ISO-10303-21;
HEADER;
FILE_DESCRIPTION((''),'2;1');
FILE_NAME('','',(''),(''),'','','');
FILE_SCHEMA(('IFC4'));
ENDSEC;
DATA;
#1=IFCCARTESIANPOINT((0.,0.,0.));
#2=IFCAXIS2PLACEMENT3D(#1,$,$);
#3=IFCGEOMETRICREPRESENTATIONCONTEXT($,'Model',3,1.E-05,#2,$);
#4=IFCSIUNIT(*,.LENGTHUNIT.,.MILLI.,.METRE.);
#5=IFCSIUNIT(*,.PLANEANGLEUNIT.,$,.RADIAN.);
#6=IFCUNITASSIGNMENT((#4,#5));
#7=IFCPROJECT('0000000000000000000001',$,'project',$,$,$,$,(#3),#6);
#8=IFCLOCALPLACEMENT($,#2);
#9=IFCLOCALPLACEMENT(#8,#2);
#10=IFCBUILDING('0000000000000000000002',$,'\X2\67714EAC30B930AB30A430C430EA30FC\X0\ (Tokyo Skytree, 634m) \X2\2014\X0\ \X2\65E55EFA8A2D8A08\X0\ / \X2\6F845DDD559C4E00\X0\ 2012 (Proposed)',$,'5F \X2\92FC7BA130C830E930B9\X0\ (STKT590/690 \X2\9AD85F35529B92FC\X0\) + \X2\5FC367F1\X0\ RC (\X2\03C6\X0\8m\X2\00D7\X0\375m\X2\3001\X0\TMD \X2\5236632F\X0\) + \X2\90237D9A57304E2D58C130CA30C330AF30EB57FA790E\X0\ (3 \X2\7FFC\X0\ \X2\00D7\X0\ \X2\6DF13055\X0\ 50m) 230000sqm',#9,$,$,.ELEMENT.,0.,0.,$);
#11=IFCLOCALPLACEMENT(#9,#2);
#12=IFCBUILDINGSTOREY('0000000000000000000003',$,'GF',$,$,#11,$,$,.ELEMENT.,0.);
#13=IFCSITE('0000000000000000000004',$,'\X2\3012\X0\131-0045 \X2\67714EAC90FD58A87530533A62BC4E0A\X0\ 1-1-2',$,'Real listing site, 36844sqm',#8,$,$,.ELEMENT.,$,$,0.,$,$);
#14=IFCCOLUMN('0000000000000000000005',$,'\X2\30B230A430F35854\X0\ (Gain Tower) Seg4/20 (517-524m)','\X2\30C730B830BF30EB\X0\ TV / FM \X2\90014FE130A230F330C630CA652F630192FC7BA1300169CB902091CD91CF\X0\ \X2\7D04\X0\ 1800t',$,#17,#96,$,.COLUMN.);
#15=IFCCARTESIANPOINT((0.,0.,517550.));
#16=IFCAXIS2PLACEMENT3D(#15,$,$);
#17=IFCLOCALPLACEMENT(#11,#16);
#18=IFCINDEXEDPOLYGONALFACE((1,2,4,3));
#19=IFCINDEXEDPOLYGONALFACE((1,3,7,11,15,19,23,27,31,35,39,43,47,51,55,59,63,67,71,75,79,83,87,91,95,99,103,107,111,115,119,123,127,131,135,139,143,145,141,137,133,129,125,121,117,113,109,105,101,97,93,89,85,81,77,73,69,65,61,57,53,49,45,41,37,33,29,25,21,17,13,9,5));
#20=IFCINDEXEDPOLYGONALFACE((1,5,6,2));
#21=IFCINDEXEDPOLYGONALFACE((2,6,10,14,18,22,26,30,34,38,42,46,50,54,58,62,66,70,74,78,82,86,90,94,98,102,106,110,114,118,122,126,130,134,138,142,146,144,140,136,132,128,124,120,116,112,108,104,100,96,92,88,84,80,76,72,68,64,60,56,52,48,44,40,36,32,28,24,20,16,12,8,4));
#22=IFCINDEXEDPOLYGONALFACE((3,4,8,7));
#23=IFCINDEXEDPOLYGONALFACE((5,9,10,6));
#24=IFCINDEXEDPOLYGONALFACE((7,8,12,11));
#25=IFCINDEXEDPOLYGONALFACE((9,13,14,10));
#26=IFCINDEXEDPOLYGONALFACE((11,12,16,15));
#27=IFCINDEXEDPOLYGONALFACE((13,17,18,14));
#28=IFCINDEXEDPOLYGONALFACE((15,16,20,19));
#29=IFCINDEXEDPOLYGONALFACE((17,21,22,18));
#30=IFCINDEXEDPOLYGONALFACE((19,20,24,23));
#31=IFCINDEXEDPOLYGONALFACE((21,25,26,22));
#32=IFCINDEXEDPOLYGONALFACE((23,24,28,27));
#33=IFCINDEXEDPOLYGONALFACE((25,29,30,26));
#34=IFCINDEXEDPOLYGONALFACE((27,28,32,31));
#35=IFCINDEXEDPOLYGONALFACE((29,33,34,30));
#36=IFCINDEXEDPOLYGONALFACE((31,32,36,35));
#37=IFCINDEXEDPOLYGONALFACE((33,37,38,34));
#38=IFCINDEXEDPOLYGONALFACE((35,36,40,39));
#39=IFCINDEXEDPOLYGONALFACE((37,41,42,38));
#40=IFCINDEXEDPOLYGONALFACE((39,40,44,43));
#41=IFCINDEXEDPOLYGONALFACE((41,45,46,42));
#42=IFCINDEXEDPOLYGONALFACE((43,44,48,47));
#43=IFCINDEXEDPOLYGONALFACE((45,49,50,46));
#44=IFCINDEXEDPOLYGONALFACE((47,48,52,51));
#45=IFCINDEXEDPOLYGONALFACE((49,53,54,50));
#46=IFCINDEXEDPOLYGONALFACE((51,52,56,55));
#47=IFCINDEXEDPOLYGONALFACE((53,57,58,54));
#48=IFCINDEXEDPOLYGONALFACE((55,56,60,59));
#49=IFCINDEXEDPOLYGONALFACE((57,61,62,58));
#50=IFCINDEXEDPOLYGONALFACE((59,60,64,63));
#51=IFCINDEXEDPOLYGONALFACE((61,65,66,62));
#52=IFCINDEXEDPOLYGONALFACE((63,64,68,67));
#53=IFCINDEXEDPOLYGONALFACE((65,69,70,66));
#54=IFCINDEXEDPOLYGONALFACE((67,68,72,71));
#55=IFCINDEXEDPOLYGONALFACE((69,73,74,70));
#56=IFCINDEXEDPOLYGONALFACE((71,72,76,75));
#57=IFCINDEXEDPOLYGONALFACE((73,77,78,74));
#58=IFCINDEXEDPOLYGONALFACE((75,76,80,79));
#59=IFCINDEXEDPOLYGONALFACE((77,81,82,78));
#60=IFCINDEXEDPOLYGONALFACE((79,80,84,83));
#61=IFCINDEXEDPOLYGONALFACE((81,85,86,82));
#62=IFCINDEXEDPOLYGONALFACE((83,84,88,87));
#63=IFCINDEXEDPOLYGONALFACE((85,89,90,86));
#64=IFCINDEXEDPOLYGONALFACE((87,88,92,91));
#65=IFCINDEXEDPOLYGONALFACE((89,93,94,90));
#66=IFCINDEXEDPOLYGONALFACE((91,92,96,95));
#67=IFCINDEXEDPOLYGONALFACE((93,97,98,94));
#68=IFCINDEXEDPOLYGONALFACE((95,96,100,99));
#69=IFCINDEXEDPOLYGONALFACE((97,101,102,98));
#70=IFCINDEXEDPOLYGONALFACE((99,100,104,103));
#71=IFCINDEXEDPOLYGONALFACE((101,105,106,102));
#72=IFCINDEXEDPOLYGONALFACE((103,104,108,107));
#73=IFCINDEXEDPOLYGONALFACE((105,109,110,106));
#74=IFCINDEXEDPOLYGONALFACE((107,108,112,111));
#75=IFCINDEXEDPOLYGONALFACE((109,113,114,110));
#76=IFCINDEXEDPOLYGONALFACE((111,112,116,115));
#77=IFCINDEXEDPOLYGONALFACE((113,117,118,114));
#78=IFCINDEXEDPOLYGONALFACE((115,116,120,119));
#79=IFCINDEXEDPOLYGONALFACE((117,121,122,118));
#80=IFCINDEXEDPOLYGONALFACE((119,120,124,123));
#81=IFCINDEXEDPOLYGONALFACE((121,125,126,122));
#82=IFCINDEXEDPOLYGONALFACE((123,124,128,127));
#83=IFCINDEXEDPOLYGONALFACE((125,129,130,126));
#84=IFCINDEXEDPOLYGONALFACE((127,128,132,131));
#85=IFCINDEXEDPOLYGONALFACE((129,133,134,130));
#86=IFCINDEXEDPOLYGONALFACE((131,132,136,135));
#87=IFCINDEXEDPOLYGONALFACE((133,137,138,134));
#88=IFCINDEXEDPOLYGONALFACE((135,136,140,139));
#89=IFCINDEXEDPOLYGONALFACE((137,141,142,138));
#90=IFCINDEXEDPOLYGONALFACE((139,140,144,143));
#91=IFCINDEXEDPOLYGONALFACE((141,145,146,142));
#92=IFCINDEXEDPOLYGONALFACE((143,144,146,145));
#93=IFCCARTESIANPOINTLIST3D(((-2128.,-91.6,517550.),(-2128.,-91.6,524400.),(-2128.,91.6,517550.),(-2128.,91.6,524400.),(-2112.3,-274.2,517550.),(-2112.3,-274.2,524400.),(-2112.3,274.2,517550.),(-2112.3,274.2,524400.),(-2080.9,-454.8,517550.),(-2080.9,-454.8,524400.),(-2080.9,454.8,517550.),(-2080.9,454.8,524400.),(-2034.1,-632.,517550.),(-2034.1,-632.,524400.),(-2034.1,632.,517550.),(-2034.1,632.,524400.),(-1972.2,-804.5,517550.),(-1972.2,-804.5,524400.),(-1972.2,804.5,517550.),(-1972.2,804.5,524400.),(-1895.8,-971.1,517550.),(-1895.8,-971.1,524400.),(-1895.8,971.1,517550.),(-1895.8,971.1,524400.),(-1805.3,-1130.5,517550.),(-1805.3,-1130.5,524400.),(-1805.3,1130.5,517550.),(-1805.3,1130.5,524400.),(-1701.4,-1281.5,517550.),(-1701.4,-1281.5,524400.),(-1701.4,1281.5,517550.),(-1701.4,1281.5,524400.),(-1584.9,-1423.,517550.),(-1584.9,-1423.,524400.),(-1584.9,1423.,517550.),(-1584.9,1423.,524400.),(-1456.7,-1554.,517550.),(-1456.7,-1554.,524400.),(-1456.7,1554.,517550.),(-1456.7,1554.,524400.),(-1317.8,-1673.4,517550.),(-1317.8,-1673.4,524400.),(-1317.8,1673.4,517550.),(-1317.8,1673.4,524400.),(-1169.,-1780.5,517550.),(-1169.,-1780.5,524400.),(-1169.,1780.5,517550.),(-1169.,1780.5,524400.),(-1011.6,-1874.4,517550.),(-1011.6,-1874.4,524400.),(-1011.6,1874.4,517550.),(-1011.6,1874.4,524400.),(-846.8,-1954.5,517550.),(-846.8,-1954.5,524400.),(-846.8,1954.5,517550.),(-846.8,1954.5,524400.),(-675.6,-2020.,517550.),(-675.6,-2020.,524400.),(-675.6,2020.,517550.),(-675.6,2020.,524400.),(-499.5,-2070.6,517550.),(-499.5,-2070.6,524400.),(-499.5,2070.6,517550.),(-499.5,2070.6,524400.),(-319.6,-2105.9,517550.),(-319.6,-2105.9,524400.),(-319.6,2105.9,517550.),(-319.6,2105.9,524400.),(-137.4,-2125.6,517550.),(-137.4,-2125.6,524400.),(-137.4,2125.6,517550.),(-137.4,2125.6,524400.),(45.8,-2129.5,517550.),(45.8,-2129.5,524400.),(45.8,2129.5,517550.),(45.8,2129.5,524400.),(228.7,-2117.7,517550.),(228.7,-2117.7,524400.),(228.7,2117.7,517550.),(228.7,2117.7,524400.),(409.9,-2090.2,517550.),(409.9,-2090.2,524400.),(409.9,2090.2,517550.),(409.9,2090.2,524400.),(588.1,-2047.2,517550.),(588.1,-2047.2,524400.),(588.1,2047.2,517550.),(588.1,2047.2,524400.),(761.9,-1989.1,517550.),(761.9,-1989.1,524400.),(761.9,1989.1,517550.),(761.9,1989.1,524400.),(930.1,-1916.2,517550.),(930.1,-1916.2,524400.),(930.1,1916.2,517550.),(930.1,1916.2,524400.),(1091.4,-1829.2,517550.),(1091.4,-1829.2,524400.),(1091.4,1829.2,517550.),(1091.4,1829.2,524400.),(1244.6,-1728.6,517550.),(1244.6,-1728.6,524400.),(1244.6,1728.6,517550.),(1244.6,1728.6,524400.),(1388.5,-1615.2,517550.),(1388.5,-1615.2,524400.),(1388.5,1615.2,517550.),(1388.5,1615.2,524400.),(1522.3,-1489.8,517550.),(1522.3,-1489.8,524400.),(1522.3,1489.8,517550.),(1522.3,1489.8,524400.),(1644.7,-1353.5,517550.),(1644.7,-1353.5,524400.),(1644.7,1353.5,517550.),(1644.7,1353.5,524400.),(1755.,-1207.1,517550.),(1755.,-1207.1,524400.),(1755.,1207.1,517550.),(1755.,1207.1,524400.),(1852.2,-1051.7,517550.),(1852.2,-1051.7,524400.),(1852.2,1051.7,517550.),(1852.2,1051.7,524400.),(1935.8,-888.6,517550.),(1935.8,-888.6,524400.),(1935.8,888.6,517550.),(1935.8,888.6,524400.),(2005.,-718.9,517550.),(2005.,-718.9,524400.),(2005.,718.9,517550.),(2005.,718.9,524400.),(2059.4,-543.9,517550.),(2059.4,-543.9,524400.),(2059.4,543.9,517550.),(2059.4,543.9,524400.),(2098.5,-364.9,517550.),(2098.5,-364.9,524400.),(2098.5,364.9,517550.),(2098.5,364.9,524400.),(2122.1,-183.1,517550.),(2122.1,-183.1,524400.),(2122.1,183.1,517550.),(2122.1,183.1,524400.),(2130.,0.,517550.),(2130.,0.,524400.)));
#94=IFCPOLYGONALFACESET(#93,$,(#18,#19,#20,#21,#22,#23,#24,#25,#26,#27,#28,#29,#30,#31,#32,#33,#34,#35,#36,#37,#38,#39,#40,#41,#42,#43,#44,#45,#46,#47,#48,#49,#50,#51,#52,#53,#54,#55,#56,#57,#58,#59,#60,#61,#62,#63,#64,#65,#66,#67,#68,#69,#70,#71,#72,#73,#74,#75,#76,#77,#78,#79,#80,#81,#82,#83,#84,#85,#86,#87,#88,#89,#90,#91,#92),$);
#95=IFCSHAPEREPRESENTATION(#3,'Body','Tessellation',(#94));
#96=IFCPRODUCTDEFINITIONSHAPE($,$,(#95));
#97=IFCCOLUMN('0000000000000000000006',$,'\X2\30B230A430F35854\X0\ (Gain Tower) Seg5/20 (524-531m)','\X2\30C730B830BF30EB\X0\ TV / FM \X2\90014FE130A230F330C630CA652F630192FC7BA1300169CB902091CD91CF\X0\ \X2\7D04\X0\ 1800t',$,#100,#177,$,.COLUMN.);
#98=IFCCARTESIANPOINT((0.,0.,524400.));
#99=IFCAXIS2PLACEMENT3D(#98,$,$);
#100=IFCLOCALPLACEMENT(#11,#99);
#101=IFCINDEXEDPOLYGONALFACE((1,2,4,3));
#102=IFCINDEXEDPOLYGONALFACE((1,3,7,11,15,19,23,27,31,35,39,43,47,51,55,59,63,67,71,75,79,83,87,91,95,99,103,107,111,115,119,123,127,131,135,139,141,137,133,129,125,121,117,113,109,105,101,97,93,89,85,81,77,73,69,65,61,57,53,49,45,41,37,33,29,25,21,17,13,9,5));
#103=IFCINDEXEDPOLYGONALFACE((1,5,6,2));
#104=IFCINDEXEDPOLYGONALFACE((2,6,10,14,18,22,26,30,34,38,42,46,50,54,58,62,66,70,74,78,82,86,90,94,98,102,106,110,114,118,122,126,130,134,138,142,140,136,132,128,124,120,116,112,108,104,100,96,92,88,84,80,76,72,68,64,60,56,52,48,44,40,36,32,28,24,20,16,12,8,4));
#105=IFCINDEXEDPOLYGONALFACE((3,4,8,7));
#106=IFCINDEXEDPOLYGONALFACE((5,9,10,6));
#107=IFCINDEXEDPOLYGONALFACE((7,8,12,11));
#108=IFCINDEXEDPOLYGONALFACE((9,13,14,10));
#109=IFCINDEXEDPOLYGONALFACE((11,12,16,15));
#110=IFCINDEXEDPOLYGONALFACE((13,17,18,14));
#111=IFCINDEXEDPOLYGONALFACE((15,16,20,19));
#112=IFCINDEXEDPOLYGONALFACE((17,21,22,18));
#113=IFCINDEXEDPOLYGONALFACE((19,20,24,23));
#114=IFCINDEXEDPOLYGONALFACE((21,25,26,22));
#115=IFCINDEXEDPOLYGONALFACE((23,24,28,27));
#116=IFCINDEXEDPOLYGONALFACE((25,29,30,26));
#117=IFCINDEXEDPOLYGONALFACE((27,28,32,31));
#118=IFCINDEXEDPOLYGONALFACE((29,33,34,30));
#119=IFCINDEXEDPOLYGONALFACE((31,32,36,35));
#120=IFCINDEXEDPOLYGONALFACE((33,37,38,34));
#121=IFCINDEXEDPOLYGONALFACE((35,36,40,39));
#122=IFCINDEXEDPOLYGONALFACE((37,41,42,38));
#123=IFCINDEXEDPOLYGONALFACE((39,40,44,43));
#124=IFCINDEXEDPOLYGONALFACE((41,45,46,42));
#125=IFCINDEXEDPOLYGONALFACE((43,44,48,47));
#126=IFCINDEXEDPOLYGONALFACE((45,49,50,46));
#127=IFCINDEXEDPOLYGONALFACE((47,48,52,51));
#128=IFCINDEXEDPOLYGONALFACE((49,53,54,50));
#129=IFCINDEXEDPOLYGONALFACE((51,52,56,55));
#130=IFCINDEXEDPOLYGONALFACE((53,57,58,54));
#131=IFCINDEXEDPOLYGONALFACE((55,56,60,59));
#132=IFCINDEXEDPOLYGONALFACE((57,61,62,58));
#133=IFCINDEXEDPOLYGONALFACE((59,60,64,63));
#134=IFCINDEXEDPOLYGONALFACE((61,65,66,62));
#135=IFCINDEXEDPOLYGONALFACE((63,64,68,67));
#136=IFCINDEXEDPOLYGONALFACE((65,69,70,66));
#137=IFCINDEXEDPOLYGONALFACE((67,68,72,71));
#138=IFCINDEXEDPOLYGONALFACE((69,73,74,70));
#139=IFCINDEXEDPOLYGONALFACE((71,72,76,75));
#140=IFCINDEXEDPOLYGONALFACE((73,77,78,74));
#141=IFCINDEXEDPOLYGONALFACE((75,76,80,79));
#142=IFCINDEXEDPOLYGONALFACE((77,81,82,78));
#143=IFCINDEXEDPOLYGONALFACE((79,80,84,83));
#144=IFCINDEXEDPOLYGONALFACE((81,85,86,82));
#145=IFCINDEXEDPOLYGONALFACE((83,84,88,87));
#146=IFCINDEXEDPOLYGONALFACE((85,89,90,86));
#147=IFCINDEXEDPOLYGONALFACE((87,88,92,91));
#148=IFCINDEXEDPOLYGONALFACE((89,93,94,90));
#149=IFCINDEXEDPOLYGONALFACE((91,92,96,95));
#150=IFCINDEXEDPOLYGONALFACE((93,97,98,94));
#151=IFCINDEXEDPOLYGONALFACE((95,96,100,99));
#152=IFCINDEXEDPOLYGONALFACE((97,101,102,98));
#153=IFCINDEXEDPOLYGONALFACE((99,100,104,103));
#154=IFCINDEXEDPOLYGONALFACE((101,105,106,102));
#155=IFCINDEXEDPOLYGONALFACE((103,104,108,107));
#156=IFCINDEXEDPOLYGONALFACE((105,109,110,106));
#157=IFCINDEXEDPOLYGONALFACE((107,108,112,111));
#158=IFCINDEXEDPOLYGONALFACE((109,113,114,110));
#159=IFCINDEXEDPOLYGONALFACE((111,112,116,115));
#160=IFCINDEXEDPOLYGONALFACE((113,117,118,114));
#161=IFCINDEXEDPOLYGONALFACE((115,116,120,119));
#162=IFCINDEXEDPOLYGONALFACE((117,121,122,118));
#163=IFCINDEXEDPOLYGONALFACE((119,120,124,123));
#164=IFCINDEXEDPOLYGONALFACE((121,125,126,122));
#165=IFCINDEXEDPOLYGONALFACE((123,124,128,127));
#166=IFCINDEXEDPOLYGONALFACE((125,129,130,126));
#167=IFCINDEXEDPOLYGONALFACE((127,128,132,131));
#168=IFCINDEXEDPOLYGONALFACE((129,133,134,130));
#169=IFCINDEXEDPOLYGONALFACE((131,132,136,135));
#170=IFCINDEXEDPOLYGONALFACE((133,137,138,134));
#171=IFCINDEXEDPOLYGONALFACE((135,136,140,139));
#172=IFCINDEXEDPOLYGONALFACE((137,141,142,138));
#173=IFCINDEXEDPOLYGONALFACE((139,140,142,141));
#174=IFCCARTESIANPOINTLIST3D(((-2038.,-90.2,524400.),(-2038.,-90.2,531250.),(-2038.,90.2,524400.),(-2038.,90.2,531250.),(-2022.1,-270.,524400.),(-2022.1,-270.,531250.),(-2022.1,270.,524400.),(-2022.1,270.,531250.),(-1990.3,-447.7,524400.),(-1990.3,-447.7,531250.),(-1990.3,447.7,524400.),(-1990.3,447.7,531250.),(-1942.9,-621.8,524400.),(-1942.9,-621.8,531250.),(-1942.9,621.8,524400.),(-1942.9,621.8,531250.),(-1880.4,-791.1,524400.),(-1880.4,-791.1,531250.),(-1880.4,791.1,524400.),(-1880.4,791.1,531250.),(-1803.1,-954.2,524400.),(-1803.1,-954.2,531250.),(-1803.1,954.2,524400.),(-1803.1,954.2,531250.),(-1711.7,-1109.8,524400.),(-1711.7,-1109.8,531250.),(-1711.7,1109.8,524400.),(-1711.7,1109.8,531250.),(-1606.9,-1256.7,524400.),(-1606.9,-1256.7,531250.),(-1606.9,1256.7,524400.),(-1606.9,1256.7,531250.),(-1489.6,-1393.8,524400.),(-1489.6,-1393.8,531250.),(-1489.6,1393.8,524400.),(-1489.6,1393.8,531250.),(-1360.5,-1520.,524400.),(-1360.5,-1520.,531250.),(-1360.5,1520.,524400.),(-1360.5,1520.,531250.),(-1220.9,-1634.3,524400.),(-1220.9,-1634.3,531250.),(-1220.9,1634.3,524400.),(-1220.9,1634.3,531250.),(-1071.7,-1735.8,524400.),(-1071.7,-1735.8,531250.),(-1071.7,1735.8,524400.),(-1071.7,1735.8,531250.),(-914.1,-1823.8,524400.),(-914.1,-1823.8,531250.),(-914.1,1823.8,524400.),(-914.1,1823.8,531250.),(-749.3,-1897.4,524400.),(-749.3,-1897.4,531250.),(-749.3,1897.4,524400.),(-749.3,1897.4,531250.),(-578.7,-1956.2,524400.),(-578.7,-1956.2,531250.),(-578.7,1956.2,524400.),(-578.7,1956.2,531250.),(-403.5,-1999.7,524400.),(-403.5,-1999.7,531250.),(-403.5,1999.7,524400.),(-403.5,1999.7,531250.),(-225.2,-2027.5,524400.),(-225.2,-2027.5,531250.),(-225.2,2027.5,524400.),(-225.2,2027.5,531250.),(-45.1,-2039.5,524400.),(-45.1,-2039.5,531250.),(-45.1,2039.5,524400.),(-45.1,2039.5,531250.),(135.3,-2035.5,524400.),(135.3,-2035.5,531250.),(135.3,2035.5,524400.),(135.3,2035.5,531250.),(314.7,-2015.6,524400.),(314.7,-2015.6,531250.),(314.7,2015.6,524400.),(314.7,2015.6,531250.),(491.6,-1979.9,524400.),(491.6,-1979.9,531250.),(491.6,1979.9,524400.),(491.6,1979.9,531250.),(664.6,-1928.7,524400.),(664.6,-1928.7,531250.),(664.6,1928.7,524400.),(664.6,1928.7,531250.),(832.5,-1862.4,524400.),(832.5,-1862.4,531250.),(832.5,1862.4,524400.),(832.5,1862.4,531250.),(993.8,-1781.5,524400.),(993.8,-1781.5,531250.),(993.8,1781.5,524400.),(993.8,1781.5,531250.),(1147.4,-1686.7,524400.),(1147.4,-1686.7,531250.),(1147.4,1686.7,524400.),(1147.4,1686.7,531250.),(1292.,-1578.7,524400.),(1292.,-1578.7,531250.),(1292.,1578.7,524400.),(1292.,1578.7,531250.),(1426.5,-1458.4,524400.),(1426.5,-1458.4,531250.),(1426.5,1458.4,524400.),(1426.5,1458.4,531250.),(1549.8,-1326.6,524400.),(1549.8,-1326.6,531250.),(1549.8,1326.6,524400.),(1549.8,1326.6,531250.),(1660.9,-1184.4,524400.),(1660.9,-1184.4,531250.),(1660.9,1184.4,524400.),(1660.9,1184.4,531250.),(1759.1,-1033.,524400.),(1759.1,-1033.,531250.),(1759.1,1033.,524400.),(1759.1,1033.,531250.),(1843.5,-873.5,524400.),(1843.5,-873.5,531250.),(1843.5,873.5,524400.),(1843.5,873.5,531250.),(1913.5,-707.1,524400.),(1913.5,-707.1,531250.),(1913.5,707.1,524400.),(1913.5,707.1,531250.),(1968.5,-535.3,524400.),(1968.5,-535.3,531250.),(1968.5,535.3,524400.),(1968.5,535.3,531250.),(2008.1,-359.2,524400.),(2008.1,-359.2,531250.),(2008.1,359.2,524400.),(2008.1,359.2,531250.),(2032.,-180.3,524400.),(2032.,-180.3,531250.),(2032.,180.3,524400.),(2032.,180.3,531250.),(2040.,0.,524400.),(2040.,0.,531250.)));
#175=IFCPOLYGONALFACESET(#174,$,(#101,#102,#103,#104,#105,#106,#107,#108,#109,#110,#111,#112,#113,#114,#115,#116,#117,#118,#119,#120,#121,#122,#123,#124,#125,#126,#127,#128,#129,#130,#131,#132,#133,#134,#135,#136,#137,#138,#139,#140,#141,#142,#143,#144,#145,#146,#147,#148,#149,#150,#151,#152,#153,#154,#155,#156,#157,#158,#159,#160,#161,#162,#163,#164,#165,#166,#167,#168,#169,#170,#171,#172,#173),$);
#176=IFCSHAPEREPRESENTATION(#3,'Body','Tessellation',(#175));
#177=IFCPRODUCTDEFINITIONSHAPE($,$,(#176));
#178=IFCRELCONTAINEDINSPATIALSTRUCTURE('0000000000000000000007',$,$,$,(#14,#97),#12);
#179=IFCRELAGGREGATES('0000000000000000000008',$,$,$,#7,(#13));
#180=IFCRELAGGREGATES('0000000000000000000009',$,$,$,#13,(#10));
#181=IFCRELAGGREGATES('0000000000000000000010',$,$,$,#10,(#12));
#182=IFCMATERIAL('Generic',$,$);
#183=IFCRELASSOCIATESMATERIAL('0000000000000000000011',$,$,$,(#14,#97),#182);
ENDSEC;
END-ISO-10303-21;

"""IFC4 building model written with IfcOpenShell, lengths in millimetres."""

from ifc_helpers import new_model, si_unit, frame, origin, origin_2d, place, context, project, spatial, circle, extrude, material, element, save


model = new_model("IFC4")

# Units and contexts
model_context = context("Model", 3, precision=1e-05, world=origin())
ifc_project = project(units=[si_unit("LENGTHUNIT", "METRE", prefix="MILLI"), si_unit("PLANEANGLEUNIT", "RADIAN")], contexts=[model_context])

# Site, building, storey
site_placement = place(None, origin())
site = spatial("IfcSite", under=ifc_project, at=site_placement, Name="〒131-0045 東京都墨田区押上 1-1-2", ObjectType="Real listing site, 36844sqm", CompositionType="ELEMENT", RefElevation=0.0)
building_placement = place(site_placement, origin())
building = spatial("IfcBuilding", under=site, at=building_placement, Name="東京スカイツリー (Tokyo Skytree, 634m) — 日建設計 / 澄川喜一 2012 (Proposed)", ObjectType="5F 鋼管トラス (STKT590/690 高張力鋼) + 心柱 RC (φ8m×375m、TMD 制振) + 連続地中壁ナックル基礎 (3 翼 × 深さ 50m) 230000sqm", CompositionType="ELEMENT", ElevationOfRefHeight=0.0, ElevationOfTerrain=0.0)
storey_placement = place(building_placement, origin())
storey = spatial("IfcBuildingStorey", under=building, at=storey_placement, Name="GF", CompositionType="ELEMENT", Elevation=0.0)

# Columns
ifc_material = material(Name="Generic")
column_1_placement = place(storey_placement, frame((0.0, 0.0, 517550.0)))
element("IfcColumn", 1, at=column_1_placement, inside=storey, material=ifc_material, Name="ゲイン塔 (Gain Tower) Seg4/20 (517-524m)", Description="デジタル TV / FM 送信アンテナ支持鋼管、構造重量 約 1800t", PredefinedType="COLUMN", context=model_context, shape_type="SweptSolid", body=[
    extrude(circle(Radius=2130.0, at=origin_2d()), frame((0.0, 0.0, 517550.0)), (0.0, 0.0, 1.0), 6850.0),
])
column_2_placement = place(storey_placement, frame((0.0, 0.0, 524400.0)))
element("IfcColumn", 2, at=column_2_placement, inside=storey, material=ifc_material, Name="ゲイン塔 (Gain Tower) Seg5/20 (524-531m)", Description="デジタル TV / FM 送信アンテナ支持鋼管、構造重量 約 1800t", PredefinedType="COLUMN", context=model_context, shape_type="SweptSolid", body=[
    extrude(circle(Radius=2040.0, at=origin_2d()), frame((0.0, 0.0, 524400.0)), (0.0, 0.0, 1.0), 6850.0),
])

save(model, "model.ifc")
